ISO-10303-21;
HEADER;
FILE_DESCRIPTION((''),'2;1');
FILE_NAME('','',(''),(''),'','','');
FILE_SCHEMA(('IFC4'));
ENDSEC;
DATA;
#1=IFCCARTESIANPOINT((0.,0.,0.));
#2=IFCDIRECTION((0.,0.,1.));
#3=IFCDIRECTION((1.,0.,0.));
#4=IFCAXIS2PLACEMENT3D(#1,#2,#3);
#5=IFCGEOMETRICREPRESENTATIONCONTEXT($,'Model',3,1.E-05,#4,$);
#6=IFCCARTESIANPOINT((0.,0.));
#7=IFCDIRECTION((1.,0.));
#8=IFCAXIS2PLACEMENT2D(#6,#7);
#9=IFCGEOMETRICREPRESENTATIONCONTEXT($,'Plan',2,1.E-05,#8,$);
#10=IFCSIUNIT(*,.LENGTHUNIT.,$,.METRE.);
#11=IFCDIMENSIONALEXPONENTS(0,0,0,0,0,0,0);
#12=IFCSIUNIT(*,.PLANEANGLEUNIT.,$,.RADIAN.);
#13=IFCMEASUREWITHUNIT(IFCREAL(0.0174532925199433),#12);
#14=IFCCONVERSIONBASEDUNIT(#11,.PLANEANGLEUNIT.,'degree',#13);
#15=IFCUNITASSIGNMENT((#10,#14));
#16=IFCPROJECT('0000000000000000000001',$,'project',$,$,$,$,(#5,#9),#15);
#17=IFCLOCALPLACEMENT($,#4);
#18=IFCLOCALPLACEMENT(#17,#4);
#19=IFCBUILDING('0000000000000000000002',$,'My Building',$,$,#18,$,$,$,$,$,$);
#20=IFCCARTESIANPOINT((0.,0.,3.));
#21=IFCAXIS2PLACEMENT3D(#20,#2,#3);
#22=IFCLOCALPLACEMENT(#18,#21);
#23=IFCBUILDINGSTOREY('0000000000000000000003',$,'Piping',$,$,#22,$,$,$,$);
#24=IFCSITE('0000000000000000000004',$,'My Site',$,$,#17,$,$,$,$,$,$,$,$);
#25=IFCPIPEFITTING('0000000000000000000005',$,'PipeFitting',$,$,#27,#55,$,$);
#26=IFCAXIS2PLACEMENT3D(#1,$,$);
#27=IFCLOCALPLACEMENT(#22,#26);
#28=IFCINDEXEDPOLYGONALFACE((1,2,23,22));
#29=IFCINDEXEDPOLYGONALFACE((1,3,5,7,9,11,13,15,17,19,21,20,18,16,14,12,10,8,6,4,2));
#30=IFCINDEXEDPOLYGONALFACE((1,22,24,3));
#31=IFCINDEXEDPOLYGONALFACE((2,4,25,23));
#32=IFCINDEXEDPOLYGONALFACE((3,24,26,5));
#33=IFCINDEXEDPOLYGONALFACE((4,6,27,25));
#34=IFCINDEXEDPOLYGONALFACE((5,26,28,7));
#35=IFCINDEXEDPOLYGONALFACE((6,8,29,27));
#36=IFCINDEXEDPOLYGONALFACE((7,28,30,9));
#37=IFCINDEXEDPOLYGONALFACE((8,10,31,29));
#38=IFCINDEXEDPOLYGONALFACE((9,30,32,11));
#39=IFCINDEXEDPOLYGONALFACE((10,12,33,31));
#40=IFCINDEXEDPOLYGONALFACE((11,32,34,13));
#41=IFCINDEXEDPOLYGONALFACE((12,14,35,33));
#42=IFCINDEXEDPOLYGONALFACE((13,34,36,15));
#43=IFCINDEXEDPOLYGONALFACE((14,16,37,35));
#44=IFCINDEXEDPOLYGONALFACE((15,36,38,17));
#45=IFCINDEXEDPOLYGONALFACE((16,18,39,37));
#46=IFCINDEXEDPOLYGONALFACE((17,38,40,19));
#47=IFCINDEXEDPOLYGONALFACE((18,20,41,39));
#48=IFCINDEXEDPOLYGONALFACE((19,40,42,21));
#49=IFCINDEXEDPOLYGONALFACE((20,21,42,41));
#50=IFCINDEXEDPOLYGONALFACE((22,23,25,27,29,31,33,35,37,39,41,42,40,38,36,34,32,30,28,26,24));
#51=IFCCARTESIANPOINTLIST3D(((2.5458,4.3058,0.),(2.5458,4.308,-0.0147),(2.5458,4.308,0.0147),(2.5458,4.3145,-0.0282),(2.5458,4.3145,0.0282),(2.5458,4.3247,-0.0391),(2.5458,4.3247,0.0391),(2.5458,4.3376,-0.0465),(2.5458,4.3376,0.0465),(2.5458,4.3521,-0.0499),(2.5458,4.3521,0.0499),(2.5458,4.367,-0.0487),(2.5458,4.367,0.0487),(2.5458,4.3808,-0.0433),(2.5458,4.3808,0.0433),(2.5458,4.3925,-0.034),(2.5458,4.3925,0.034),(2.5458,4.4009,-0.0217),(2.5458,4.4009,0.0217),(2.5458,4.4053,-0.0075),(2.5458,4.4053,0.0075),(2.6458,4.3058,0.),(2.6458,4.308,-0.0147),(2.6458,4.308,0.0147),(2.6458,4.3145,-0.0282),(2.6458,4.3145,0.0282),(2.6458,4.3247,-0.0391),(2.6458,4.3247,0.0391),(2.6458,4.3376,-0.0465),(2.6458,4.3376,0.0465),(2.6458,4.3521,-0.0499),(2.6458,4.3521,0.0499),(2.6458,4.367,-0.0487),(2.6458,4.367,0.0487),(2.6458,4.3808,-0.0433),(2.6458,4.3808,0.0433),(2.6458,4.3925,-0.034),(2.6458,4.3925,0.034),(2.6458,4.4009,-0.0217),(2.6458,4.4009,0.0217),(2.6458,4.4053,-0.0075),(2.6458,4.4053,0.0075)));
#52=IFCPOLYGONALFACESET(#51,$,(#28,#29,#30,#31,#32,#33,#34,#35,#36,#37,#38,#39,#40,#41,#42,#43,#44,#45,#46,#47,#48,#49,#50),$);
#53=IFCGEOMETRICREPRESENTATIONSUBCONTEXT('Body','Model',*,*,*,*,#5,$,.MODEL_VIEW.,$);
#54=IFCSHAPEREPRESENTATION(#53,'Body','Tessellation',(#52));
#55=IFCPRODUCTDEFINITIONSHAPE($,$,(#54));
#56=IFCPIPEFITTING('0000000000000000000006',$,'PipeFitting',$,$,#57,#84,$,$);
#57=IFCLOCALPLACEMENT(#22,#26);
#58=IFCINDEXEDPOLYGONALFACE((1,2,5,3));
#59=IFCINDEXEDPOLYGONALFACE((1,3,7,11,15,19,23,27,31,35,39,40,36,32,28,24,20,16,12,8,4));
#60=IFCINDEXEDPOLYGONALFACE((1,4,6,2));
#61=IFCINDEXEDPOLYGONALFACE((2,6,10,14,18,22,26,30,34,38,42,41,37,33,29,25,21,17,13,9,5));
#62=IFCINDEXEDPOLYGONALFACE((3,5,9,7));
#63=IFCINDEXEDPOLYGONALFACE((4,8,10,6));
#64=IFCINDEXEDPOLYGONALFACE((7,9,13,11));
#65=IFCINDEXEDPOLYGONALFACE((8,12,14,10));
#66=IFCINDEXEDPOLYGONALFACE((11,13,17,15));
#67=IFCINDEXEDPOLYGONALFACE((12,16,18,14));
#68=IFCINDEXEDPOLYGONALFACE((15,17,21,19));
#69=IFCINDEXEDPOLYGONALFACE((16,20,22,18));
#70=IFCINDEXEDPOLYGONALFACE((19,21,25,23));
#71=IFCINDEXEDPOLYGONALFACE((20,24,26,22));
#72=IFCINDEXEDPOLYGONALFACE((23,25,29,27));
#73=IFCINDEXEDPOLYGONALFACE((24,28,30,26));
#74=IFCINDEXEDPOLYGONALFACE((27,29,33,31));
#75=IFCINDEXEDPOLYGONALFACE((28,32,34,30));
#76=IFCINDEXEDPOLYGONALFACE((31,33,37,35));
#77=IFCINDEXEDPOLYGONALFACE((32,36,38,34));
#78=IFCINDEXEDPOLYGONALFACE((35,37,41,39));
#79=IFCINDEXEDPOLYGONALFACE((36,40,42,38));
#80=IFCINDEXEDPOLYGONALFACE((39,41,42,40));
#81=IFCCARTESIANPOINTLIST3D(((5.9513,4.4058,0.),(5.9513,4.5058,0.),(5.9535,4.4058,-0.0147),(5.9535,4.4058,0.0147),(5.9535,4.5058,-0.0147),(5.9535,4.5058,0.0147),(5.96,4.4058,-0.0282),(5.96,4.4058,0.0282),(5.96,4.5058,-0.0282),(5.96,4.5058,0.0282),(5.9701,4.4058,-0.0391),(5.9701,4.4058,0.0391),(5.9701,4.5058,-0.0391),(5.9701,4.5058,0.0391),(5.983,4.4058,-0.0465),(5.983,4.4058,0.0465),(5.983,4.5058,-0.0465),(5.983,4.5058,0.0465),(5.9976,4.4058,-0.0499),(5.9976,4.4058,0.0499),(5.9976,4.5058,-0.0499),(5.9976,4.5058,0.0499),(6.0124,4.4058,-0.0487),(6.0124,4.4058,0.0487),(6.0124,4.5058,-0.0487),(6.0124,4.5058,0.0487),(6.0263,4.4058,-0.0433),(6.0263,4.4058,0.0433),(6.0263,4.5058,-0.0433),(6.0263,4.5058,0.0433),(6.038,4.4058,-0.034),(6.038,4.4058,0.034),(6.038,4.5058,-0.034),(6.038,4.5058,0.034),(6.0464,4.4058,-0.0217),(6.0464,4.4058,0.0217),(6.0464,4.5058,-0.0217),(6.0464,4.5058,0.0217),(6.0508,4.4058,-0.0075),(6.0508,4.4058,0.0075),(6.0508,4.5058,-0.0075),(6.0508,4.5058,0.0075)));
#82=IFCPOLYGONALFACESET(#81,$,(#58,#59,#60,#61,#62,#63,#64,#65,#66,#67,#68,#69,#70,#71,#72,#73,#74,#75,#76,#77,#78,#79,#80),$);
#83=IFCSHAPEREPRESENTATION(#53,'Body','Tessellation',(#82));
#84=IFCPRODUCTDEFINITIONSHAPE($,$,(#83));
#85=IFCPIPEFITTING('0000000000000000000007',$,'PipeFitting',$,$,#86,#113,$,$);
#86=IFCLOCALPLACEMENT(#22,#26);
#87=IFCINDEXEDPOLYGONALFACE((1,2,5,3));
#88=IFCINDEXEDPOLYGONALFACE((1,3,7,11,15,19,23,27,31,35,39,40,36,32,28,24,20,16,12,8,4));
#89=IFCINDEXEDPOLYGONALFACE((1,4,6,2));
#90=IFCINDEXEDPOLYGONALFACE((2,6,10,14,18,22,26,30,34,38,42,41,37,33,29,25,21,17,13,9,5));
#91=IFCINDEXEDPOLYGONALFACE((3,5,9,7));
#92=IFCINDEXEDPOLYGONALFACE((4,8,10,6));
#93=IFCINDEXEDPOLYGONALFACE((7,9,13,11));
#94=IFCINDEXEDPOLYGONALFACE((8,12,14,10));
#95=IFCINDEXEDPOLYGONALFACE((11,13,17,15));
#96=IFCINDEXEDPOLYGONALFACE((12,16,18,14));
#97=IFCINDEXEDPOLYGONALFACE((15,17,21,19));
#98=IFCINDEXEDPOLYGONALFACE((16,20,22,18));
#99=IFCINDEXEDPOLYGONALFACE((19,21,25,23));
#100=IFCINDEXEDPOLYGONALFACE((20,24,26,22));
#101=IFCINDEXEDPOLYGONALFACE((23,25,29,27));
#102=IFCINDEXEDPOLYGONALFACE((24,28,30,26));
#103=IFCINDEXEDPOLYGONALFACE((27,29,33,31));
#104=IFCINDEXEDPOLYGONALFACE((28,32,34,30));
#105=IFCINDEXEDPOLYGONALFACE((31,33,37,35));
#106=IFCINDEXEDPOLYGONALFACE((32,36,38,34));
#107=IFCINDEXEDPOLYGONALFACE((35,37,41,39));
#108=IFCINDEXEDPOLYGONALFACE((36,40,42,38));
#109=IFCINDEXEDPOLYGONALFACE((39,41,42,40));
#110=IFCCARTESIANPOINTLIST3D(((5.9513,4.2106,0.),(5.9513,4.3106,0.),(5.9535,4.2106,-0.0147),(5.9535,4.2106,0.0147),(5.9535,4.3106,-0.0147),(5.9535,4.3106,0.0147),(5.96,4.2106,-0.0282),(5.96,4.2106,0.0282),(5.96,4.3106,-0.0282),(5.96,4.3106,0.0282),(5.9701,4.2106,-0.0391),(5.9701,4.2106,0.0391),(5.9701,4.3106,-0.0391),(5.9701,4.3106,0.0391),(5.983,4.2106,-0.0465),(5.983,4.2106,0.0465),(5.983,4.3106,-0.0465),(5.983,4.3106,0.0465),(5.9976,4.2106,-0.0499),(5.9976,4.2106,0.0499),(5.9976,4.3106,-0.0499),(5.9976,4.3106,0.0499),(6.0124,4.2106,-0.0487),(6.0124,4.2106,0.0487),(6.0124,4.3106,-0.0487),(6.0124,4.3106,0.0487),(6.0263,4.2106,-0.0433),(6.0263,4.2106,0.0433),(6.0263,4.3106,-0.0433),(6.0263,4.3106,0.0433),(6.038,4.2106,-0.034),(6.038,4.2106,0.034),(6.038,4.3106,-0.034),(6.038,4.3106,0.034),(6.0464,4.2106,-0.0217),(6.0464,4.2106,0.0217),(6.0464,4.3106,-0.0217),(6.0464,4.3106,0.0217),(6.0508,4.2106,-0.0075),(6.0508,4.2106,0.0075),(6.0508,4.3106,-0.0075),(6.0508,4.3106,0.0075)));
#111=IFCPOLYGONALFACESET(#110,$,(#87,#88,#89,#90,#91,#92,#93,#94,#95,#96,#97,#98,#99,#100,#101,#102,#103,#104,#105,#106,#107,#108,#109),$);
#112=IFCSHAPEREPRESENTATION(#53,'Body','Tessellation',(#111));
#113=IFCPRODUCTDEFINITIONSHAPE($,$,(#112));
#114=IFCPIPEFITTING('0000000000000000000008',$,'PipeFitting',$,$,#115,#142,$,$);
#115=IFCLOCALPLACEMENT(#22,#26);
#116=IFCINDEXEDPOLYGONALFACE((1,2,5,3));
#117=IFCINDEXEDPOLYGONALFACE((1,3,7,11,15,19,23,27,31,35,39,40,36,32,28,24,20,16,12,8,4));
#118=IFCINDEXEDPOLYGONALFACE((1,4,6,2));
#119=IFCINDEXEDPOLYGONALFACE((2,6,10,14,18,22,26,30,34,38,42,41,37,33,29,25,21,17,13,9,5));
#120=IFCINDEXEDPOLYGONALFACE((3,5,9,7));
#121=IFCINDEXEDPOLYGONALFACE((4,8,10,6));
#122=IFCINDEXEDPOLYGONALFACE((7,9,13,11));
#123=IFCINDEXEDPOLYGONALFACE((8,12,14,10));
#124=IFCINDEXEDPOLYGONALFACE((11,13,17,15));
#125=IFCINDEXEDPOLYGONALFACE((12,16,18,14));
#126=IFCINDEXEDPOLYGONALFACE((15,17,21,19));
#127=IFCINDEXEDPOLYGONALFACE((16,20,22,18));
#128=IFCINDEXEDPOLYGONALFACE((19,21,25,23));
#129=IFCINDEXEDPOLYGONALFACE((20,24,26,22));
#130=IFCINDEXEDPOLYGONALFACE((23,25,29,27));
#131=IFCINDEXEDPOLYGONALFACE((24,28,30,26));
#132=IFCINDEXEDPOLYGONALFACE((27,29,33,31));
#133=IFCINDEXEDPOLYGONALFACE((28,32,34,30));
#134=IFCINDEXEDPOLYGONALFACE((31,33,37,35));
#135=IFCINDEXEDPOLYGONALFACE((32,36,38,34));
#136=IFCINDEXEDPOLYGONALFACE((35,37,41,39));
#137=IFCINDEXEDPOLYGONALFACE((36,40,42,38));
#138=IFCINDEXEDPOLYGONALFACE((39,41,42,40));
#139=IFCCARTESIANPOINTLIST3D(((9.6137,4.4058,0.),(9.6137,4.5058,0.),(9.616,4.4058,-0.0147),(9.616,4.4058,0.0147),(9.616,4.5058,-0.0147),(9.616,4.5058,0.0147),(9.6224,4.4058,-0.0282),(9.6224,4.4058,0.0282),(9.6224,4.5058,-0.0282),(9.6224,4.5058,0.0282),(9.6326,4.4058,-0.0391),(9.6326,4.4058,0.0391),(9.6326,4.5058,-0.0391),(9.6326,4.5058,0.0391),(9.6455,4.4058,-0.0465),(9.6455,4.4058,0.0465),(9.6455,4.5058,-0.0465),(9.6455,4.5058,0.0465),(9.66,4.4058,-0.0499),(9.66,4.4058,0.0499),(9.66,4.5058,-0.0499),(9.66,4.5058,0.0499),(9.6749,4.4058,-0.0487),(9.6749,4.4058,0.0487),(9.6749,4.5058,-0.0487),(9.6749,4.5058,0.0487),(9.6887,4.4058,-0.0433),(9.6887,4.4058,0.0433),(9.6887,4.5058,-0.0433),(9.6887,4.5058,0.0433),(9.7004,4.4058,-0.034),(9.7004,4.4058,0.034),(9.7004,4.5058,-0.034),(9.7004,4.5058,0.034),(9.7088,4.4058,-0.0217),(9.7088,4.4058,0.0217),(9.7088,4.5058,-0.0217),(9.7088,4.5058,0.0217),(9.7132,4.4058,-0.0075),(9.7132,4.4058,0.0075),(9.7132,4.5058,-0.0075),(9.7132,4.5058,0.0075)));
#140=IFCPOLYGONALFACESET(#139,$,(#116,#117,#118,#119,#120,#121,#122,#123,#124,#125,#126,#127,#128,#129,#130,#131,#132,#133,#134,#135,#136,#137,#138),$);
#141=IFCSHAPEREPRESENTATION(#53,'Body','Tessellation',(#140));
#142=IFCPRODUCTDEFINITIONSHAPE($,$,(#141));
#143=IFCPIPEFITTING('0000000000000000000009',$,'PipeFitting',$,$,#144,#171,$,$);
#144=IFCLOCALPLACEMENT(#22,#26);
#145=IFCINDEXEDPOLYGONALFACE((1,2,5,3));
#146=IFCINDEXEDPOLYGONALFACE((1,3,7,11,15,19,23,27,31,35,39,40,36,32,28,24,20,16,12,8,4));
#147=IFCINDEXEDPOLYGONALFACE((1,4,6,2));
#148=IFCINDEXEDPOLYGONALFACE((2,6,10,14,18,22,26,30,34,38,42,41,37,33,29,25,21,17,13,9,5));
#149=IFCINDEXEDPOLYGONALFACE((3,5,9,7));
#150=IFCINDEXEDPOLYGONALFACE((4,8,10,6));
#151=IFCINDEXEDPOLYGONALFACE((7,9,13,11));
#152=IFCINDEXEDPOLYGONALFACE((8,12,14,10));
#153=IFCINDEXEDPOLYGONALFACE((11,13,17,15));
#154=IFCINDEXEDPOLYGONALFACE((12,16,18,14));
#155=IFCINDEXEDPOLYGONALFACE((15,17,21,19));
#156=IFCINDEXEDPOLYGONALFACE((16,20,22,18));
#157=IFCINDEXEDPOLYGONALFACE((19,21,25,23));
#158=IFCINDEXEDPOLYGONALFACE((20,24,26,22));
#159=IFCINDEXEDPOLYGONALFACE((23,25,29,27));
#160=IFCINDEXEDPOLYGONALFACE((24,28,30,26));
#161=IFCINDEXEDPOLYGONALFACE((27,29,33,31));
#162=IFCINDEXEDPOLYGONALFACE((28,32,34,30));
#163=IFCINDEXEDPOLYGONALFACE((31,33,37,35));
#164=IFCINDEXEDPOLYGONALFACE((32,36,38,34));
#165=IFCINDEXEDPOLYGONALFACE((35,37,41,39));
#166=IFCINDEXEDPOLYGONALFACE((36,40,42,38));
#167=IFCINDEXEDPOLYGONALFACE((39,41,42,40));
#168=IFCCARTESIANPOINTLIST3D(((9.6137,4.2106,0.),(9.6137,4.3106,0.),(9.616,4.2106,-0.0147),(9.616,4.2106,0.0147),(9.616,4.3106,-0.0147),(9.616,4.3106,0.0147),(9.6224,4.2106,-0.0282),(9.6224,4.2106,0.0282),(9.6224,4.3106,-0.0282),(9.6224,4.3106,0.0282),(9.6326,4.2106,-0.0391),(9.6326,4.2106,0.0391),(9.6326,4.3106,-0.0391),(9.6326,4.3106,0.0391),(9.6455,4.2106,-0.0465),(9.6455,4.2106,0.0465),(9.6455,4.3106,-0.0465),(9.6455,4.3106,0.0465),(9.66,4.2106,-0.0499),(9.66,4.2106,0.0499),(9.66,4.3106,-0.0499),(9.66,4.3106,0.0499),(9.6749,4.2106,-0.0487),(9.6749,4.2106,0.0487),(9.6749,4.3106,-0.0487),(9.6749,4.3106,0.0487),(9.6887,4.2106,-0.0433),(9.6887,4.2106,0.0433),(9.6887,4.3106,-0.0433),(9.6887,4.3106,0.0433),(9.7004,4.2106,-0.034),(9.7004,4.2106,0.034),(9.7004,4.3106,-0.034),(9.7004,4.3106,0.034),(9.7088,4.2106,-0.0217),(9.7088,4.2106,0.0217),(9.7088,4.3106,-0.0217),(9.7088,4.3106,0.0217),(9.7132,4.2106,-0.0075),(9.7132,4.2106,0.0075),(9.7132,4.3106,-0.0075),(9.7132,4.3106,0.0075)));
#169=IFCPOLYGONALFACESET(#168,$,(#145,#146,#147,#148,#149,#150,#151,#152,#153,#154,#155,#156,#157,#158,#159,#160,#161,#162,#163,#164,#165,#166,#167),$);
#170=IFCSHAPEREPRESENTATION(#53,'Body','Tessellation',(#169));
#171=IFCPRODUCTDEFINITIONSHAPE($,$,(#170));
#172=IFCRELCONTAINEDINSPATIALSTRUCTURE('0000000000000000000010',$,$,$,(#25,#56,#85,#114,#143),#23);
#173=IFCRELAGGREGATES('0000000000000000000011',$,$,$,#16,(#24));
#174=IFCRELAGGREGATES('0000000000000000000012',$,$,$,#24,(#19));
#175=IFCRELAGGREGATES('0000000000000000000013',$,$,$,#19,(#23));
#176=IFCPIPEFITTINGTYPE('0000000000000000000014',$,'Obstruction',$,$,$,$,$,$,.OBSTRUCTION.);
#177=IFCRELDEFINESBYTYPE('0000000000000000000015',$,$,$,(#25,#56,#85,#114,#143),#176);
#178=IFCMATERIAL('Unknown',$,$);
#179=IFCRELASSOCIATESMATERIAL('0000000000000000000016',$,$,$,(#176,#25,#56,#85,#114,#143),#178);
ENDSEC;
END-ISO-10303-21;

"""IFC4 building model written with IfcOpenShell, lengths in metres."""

from ifc_helpers import new_model, entity, si_unit, converted_unit, frame, origin_with_axes, origin_2d_with_axis, place, context, subcontext, project, spatial, circle, extrude, material, material_profile, profile_set, profile_usage, type_object, element, save


model = new_model("IFC4")

# Units and contexts
model_context = context("Model", 3, precision=1e-05, world=origin_with_axes())
plan_context = context("Plan", 2, precision=1e-05, world=origin_2d_with_axis())
body_context = subcontext(model_context, "Body", "Model", "MODEL_VIEW")
ifc_project = project(units=[si_unit("LENGTHUNIT", "METRE"), converted_unit("PLANEANGLEUNIT", "degree", entity("IfcReal", 0.0174532925199433), si_unit("PLANEANGLEUNIT", "RADIAN"), dimensions=[0, 0, 0, 0, 0, 0, 0])], contexts=[model_context, plan_context])

# Site, building, storey
site_placement = place(None, origin_with_axes())
site = spatial("IfcSite", under=ifc_project, at=site_placement, Name="My Site")
building_placement = place(site_placement, origin_with_axes())
building = spatial("IfcBuilding", under=site, at=building_placement, Name="My Building")
storey_placement = place(building_placement, frame((0.0, 0.0, 3.0), z_axis=(0.0, 0.0, 1.0), x_axis=(1.0, 0.0, 0.0)))
storey = spatial("IfcBuildingStorey", under=building, at=storey_placement, Name="Piping")

# Shared definitions
ifc_material = material(Name="Unknown")

# Pipe fittings
ifc_material_profile_1 = material_profile(ifc_material, circle(Radius=0.05))
ifc_profile_set_1 = profile_set([ifc_material_profile_1])
ifc_profile_usage_1 = profile_usage(ifc_profile_set_1, cardinal=5)
pipe_fitting_type_1 = type_object("IfcPipeFittingType", Name="Obstruction", PredefinedType="OBSTRUCTION", material=ifc_profile_set_1)
pipe_fitting_1_placement = place(storey_placement, frame((2.6458, 4.3558, 0.0), z_axis=(-1.0, 0.0, 0.0), x_axis=(0.0, -1.0, 0.0)))
element("IfcPipeFitting", 1, at=pipe_fitting_1_placement, inside=storey, type_object=pipe_fitting_type_1, material=ifc_profile_usage_1, Name="PipeFitting", context=body_context, shape_type="SweptSolid", body=[
    extrude(circle(Radius=0.05), origin_with_axes(), (0.0, 0.0, 1.0), 0.1),
])
ifc_profile_usage_2 = profile_usage(ifc_profile_set_1, cardinal=5)
pipe_fitting_2_placement = place(storey_placement, frame((6.0013, 4.5058, 0.0), z_axis=(0.0, -1.0, 0.0), x_axis=(-1.0, 0.0, 0.0)))
element("IfcPipeFitting", 2, at=pipe_fitting_2_placement, inside=storey, type_object=pipe_fitting_type_1, material=ifc_profile_usage_2, Name="PipeFitting", context=body_context, shape_type="SweptSolid", body=[
    extrude(circle(Radius=0.05), origin_with_axes(), (0.0, 0.0, 1.0), 0.1),
])
ifc_profile_usage_3 = profile_usage(ifc_profile_set_1, cardinal=5)
pipe_fitting_3_placement = place(storey_placement, frame((6.0013, 4.3106, 0.0), z_axis=(0.0, -1.0, 0.0), x_axis=(-1.0, 0.0, 0.0)))
element("IfcPipeFitting", 3, at=pipe_fitting_3_placement, inside=storey, type_object=pipe_fitting_type_1, material=ifc_profile_usage_3, Name="PipeFitting", context=body_context, shape_type="SweptSolid", body=[
    extrude(circle(Radius=0.05), origin_with_axes(), (0.0, 0.0, 1.0), 0.1),
])
ifc_profile_usage_4 = profile_usage(ifc_profile_set_1, cardinal=5)
pipe_fitting_4_placement = place(storey_placement, frame((9.6637, 4.5058, 0.0), z_axis=(0.0, -1.0, 0.0), x_axis=(-1.0, 0.0, 0.0)))
element("IfcPipeFitting", 4, at=pipe_fitting_4_placement, inside=storey, type_object=pipe_fitting_type_1, material=ifc_profile_usage_4, Name="PipeFitting", context=body_context, shape_type="SweptSolid", body=[
    extrude(circle(Radius=0.05), origin_with_axes(), (0.0, 0.0, 1.0), 0.1),
])
ifc_profile_usage_5 = profile_usage(ifc_profile_set_1, cardinal=5)
pipe_fitting_5_placement = place(storey_placement, frame((9.6637, 4.3106, 0.0), z_axis=(0.0, -1.0, 0.0), x_axis=(-1.0, 0.0, 0.0)))
element("IfcPipeFitting", 5, at=pipe_fitting_5_placement, inside=storey, type_object=pipe_fitting_type_1, material=ifc_profile_usage_5, Name="PipeFitting", context=body_context, shape_type="SweptSolid", body=[
    extrude(circle(Radius=0.05), origin_with_axes(), (0.0, 0.0, 1.0), 0.1),
])

save(model, "model.ifc")
